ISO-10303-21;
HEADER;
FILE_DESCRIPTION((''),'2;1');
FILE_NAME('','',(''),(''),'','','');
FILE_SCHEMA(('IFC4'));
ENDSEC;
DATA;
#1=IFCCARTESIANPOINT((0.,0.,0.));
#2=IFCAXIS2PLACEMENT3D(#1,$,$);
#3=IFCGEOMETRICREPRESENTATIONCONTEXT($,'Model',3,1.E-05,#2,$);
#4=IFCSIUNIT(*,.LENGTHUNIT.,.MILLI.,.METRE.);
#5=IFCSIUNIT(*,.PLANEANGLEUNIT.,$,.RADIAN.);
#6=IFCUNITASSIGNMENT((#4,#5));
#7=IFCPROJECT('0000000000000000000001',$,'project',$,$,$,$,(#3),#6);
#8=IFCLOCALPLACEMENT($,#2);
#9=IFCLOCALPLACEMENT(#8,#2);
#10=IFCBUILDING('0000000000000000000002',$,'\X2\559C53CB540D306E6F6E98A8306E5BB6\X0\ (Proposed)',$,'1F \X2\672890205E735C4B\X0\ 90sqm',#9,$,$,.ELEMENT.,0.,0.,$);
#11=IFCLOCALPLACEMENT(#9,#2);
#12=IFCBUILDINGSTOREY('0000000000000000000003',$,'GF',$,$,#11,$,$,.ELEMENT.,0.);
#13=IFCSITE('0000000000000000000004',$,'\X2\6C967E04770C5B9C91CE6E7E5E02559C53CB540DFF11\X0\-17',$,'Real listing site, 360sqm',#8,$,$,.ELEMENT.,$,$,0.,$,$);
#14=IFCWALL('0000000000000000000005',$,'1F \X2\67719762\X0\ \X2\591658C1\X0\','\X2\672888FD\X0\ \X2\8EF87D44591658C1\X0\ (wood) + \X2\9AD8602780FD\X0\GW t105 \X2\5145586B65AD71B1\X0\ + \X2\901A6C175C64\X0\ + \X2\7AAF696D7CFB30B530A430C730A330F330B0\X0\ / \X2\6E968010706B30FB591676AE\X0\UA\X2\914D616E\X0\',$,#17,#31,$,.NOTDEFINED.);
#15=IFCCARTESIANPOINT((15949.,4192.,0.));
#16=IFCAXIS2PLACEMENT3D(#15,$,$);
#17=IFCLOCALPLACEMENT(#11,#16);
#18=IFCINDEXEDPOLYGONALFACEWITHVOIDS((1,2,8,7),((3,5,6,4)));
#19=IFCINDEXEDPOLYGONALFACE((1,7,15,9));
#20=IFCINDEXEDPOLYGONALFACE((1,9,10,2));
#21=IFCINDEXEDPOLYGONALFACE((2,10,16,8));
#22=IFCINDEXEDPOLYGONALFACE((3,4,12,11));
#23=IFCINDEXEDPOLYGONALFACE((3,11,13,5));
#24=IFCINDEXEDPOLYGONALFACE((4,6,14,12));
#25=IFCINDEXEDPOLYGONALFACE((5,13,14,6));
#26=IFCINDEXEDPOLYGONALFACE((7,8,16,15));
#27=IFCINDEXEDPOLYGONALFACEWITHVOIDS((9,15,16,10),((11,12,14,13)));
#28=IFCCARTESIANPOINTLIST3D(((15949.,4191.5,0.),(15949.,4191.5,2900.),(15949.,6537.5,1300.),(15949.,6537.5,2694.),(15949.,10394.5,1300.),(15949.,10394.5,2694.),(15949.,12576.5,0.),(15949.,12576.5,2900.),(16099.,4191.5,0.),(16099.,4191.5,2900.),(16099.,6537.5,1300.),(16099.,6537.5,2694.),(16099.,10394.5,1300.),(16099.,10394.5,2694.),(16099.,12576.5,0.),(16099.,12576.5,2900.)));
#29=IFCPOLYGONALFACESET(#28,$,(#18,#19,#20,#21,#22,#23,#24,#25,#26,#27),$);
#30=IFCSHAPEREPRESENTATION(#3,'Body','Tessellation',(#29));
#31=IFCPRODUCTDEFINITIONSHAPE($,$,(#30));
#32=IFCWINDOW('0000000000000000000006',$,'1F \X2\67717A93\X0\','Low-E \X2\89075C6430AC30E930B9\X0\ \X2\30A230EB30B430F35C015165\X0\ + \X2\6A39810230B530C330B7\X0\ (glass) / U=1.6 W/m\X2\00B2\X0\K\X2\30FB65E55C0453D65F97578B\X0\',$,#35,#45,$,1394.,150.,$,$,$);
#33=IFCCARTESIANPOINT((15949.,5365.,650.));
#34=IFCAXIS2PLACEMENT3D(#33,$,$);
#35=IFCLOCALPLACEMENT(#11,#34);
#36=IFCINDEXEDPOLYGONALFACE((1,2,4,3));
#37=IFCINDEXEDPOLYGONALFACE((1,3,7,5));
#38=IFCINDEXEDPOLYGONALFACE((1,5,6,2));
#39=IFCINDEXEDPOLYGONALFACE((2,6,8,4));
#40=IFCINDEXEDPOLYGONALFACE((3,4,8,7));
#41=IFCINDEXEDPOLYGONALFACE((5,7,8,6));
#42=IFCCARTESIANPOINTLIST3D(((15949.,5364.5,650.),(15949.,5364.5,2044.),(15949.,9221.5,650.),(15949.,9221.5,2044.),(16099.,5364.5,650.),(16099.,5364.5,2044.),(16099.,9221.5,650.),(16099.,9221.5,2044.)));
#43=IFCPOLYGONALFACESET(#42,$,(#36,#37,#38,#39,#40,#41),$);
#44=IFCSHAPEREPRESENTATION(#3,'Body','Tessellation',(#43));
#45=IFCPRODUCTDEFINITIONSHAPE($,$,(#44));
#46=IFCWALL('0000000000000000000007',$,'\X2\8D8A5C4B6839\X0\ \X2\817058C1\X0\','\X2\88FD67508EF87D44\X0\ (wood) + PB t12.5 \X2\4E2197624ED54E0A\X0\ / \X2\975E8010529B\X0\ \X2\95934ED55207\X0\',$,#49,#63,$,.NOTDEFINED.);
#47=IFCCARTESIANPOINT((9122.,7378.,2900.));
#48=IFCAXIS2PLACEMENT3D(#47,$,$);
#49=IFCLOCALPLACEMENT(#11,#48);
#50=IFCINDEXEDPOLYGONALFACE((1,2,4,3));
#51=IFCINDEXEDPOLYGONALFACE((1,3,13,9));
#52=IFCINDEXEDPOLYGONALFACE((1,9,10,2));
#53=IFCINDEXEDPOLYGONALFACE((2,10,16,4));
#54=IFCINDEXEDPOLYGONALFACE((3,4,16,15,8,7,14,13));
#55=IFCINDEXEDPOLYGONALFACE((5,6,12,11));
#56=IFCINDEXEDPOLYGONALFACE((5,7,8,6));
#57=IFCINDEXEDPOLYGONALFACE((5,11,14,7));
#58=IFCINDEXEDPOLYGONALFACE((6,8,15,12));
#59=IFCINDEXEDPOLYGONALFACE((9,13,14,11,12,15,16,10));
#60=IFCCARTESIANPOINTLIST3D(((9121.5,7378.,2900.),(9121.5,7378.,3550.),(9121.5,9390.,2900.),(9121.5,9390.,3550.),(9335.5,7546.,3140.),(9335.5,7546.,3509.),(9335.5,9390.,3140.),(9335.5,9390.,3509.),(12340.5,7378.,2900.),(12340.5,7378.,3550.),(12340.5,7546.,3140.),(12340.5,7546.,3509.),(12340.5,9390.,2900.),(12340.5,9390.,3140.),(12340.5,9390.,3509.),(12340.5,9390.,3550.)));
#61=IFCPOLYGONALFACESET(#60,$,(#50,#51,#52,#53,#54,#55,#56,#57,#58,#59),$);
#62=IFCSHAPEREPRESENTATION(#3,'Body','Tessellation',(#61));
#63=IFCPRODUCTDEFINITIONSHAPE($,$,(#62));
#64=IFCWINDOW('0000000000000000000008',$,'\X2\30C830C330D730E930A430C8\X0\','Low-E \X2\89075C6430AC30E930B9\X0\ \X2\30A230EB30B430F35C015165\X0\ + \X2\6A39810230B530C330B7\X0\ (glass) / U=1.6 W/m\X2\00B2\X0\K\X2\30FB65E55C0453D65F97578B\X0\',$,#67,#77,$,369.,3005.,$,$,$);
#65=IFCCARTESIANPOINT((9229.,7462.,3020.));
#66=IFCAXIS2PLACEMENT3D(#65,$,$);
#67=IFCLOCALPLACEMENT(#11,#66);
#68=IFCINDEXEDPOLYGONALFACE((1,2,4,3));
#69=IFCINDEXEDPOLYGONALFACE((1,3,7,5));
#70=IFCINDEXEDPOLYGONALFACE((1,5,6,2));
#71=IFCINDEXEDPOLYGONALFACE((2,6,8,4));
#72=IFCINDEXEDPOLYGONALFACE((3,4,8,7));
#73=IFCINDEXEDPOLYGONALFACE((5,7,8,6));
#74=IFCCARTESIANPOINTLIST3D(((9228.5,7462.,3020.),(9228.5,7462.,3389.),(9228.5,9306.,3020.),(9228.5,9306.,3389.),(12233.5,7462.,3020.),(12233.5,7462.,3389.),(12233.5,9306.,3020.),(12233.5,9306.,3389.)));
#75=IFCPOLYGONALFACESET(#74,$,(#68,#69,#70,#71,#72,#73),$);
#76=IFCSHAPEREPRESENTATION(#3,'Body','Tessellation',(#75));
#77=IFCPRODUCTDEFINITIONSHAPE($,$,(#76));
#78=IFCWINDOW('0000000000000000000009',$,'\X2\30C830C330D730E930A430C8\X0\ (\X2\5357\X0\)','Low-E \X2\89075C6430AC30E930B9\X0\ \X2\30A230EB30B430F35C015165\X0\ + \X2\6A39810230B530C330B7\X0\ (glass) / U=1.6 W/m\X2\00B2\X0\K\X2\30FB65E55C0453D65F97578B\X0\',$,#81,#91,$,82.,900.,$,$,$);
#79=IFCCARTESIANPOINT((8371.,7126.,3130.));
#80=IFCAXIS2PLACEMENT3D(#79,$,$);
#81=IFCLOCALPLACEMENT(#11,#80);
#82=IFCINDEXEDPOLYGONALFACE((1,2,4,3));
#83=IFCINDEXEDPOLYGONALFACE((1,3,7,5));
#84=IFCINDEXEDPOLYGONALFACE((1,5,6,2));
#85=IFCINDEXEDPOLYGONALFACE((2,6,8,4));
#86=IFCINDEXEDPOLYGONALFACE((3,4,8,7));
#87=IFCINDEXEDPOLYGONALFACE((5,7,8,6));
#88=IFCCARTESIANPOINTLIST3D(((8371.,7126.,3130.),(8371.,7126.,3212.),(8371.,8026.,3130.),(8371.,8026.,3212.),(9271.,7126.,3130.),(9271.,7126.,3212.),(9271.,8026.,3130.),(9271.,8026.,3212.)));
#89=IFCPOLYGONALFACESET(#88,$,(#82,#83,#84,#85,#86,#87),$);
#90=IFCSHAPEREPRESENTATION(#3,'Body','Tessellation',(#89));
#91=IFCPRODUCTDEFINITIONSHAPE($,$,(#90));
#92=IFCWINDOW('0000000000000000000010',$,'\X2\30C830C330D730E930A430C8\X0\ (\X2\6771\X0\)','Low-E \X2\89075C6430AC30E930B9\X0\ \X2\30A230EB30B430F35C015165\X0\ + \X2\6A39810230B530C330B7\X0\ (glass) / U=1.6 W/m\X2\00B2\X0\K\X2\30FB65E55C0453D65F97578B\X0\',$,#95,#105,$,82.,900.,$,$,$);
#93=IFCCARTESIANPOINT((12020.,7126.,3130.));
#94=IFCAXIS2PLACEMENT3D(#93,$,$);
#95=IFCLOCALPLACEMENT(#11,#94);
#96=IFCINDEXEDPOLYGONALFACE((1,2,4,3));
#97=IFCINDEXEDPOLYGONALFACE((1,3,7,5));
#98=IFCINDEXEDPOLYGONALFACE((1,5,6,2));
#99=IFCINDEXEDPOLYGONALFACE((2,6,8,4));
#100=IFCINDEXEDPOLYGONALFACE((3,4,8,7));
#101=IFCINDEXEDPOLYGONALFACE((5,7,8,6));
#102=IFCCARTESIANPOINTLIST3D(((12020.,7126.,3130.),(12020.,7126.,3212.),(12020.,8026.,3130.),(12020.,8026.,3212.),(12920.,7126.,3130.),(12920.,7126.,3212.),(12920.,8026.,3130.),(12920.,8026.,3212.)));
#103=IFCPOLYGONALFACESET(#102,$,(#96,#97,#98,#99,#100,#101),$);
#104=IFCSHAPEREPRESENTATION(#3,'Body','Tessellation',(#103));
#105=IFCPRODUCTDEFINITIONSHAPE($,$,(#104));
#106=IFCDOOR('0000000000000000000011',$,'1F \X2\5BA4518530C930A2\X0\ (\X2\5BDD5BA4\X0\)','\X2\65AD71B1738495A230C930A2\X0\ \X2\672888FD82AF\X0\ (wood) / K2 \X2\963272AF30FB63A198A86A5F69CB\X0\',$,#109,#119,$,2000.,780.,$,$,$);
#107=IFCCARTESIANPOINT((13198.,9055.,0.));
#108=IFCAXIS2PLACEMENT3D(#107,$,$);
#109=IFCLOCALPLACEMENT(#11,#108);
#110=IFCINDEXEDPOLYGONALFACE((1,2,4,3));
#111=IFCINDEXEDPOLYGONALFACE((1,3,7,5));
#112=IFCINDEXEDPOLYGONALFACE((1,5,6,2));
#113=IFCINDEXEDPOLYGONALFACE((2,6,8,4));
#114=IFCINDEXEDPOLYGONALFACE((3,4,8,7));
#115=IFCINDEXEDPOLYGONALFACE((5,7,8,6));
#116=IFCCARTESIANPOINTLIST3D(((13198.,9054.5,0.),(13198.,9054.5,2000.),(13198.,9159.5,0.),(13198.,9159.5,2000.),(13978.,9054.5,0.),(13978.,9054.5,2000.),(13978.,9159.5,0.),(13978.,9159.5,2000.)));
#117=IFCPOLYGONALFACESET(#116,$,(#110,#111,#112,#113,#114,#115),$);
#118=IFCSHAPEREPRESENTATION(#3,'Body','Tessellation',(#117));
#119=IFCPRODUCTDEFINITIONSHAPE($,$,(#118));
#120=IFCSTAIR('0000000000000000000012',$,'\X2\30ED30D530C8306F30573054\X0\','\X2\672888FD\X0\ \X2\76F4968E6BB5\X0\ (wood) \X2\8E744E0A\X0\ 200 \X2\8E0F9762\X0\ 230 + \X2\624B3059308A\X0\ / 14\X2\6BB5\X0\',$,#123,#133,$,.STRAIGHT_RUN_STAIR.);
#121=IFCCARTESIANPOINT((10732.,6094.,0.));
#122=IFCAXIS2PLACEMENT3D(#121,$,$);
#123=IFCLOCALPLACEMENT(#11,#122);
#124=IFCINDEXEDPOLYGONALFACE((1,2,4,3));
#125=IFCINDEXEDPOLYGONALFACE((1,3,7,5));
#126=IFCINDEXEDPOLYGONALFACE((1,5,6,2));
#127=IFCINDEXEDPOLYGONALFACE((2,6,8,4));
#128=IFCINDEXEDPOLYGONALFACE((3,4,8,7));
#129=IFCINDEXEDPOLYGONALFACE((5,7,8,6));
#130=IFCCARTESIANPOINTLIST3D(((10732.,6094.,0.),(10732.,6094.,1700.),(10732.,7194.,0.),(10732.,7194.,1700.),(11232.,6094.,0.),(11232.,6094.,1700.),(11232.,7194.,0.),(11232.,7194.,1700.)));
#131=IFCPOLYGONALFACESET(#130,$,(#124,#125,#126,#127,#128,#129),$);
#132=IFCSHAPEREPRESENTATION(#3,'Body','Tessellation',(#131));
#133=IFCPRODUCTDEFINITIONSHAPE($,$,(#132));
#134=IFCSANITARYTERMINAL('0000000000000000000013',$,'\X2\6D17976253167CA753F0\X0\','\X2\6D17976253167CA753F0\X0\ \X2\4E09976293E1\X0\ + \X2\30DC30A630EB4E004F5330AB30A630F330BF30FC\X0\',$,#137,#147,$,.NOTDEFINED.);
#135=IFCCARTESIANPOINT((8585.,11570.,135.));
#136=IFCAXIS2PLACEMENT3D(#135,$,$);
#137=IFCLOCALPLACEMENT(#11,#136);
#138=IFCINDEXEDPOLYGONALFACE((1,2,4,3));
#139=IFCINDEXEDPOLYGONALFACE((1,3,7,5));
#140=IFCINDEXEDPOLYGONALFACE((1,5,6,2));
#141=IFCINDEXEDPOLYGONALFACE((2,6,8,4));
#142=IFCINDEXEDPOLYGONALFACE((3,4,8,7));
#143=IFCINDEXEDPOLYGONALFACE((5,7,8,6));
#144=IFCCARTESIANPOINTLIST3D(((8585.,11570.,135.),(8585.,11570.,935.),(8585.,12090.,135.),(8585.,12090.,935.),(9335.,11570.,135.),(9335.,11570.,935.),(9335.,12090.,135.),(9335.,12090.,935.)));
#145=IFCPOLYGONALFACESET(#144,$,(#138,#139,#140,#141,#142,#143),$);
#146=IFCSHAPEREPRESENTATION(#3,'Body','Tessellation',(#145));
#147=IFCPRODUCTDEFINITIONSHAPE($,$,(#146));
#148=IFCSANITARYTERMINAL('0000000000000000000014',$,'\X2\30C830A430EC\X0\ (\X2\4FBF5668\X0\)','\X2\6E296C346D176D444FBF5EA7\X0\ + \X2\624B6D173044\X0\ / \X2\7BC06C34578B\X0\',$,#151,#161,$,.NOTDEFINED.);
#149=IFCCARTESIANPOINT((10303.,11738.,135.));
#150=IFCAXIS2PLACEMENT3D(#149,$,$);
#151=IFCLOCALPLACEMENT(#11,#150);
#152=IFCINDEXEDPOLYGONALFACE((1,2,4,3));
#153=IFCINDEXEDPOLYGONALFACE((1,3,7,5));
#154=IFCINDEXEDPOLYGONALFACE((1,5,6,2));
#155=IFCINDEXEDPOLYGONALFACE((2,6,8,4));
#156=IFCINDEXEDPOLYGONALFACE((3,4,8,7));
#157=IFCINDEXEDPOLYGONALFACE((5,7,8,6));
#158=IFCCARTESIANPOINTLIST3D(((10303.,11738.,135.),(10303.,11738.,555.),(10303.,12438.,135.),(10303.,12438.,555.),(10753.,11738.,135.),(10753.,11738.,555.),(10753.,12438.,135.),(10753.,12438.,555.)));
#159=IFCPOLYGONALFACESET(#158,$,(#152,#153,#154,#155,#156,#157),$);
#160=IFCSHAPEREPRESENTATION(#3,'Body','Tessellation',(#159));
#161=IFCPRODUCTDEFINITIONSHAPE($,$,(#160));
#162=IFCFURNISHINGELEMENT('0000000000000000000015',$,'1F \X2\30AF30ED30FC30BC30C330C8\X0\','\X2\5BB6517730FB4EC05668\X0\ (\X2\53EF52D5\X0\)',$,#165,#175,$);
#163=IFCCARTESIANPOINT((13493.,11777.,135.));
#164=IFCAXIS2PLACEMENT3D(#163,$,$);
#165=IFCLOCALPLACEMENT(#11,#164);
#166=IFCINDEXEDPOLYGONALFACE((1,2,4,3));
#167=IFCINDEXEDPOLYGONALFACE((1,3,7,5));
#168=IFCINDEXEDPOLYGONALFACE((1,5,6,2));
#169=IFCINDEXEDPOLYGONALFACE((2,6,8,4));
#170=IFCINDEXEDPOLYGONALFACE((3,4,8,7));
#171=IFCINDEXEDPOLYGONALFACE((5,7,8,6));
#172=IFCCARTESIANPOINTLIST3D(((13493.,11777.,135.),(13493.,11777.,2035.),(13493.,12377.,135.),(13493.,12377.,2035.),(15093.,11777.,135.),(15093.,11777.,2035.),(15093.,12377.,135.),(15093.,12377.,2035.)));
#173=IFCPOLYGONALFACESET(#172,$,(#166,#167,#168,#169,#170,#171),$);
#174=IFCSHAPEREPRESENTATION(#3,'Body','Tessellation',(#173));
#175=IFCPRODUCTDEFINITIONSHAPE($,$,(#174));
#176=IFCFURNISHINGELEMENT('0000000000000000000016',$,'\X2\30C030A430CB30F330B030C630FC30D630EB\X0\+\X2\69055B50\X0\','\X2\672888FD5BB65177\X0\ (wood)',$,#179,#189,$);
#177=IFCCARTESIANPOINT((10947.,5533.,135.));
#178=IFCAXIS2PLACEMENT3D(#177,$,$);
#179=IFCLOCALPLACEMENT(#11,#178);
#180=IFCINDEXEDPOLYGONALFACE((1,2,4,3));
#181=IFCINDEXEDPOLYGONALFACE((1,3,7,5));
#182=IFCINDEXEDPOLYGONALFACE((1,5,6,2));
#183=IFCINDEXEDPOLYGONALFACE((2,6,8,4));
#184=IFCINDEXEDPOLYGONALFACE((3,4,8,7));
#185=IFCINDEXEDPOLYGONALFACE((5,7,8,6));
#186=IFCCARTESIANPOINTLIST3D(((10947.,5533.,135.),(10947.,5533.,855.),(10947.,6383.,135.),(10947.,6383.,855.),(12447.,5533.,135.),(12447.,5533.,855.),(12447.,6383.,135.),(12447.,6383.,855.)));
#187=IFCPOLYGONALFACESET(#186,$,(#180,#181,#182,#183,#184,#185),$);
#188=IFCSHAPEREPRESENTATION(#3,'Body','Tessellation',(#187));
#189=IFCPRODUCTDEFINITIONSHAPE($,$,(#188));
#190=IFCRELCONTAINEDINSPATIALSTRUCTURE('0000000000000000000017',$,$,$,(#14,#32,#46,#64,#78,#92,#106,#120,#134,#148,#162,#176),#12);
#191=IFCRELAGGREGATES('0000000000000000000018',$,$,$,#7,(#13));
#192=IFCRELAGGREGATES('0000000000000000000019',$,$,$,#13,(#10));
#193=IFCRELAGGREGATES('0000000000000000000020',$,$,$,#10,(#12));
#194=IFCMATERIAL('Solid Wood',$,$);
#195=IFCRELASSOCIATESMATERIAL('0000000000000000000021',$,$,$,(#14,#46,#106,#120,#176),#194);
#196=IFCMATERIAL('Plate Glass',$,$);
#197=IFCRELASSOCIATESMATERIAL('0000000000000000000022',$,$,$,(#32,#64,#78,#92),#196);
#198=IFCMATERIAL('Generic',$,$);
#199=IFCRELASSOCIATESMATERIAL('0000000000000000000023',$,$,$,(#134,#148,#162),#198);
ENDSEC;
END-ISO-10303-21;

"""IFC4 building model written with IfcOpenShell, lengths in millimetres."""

from ifc_helpers import new_model, si_unit, frame, frame_2d, origin, place, context, project, spatial, rectangle, extrude, material, element, fill, save


model = new_model("IFC4")

# Units and contexts
model_context = context("Model", 3, precision=1e-05, world=origin())
ifc_project = project(units=[si_unit("LENGTHUNIT", "METRE", prefix="MILLI"), si_unit("PLANEANGLEUNIT", "RADIAN")], contexts=[model_context])

# Site, building, storey
site_placement = place(None, origin())
site = spatial("IfcSite", under=ifc_project, at=site_placement, Name="沖縄県宜野湾市喜友名１-17", ObjectType="Real listing site, 360sqm", CompositionType="ELEMENT", RefElevation=0.0)
building_placement = place(site_placement, origin())
building = spatial("IfcBuilding", under=site, at=building_placement, Name="喜友名の潮風の家 (Proposed)", ObjectType="1F 木造平屋 90sqm", CompositionType="ELEMENT", ElevationOfRefHeight=0.0, ElevationOfTerrain=0.0)
storey_placement = place(building_placement, origin())
storey = spatial("IfcBuildingStorey", under=building, at=storey_placement, Name="GF", CompositionType="ELEMENT", Elevation=0.0)

# Wall, opening, window
ifc_material_1 = material(Name="Solid Wood")
wall_1_placement = place(storey_placement, frame((15949.0, 4192.0, 0.0)))
wall_1 = element("IfcWall", 1, at=wall_1_placement, inside=storey, material=ifc_material_1, Name="1F 東面 外壁", Description="木製 軸組外壁 (wood) + 高性能GW t105 充填断熱 + 通気層 + 窯業系サイディング / 準耐火・外皮UA配慮", PredefinedType="NOTDEFINED", context=model_context, shape_type="SweptSolid", body=[
    extrude(rectangle(XDim=150.0, YDim=8385.0, at=frame_2d((75.0, 4192.0))), frame((15949.0, 4192.0, 0.0)), (0.0, 0.0, 1.0), 2900.0),
])
opening_1_placement = place(storey_placement, frame((15949.0, 5365.0, 650.0)))
opening_1 = element("IfcOpeningElement", 2, at=opening_1_placement, cuts=wall_1, PredefinedType="NOTDEFINED", context=model_context, shape_type="SweptSolid", body=[
    extrude(rectangle(XDim=150.0, YDim=3857.0, at=frame_2d((75.0, 1928.0))), frame((15949.0, 5365.0, 650.0)), (0.0, 0.0, 1.0), 1394.0),
])
ifc_material_2 = material(Name="Plate Glass")
window_1_placement = place(storey_placement, frame((15949.0, 5365.0, 650.0)))
window_1 = element("IfcWindow", 3, at=window_1_placement, inside=storey, material=ifc_material_2, Name="1F 東窓", Description="Low-E 複層ガラス アルゴン封入 + 樹脂サッシ (glass) / U=1.6 W/m²K・日射取得型", OverallHeight=1394.0, OverallWidth=150.0, context=model_context, shape_type="SweptSolid", body=[
    extrude(rectangle(XDim=150.0, YDim=3857.0, at=frame_2d((75.0, 1928.0))), frame((15949.0, 5365.0, 650.0)), (0.0, 0.0, 1.0), 1394.0),
])
fill(opening_1, window_1)

# Wall, openings, windows
wall_2_placement = place(storey_placement, frame((9122.0, 7378.0, 2900.0)))
wall_2 = element("IfcWall", 4, at=wall_2_placement, inside=storey, material=ifc_material_1, Name="越屋根 腰壁", Description="製材軸組 (wood) + PB t12.5 両面仕上 / 非耐力 間仕切", PredefinedType="NOTDEFINED", context=model_context, shape_type="SweptSolid", body=[
    extrude(rectangle(XDim=3219.0, YDim=2012.0, at=frame_2d((1609.0, 1006.0))), frame((9122.0, 7378.0, 2900.0)), (0.0, 0.0, 1.0), 650.0),
])
opening_2_placement = place(storey_placement, frame((9229.0, 7462.0, 3020.0)))
opening_2 = element("IfcOpeningElement", 5, at=opening_2_placement, cuts=wall_2, PredefinedType="NOTDEFINED", context=model_context, shape_type="SweptSolid", body=[
    extrude(rectangle(XDim=3005.0, YDim=1844.0, at=frame_2d((1502.0, 922.0))), frame((9229.0, 7462.0, 3020.0)), (0.0, 0.0, 1.0), 369.0),
])
opening_3_placement = place(storey_placement, frame((8371.0, 7126.0, 3130.0)))
opening_3 = element("IfcOpeningElement", 6, at=opening_3_placement, cuts=wall_2, PredefinedType="NOTDEFINED", context=model_context, shape_type="SweptSolid", body=[
    extrude(rectangle(XDim=900.0, YDim=900.0, at=frame_2d((450.0, 450.0))), frame((8371.0, 7126.0, 3130.0)), (0.0, 0.0, 1.0), 82.0),
])
opening_4_placement = place(storey_placement, frame((12020.0, 7126.0, 3130.0)))
opening_4 = element("IfcOpeningElement", 7, at=opening_4_placement, cuts=wall_2, PredefinedType="NOTDEFINED", context=model_context, shape_type="SweptSolid", body=[
    extrude(rectangle(XDim=900.0, YDim=900.0, at=frame_2d((450.0, 450.0))), frame((12020.0, 7126.0, 3130.0)), (0.0, 0.0, 1.0), 82.0),
])
window_2_placement = place(storey_placement, frame((9229.0, 7462.0, 3020.0)))
window_2 = element("IfcWindow", 8, at=window_2_placement, inside=storey, material=ifc_material_2, Name="トップライト", Description="Low-E 複層ガラス アルゴン封入 + 樹脂サッシ (glass) / U=1.6 W/m²K・日射取得型", OverallHeight=369.0, OverallWidth=3005.0, context=model_context, shape_type="SweptSolid", body=[
    extrude(rectangle(XDim=3005.0, YDim=1844.0, at=frame_2d((1502.0, 922.0))), frame((9229.0, 7462.0, 3020.0)), (0.0, 0.0, 1.0), 369.0),
])
fill(opening_2, window_2)
window_3_placement = place(storey_placement, frame((8371.0, 7126.0, 3130.0)))
window_3 = element("IfcWindow", 9, at=window_3_placement, inside=storey, material=ifc_material_2, Name="トップライト (南)", Description="Low-E 複層ガラス アルゴン封入 + 樹脂サッシ (glass) / U=1.6 W/m²K・日射取得型", OverallHeight=82.0, OverallWidth=900.0, context=model_context, shape_type="SweptSolid", body=[
    extrude(rectangle(XDim=900.0, YDim=900.0, at=frame_2d((450.0, 450.0))), frame((8371.0, 7126.0, 3130.0)), (0.0, 0.0, 1.0), 82.0),
])
fill(opening_3, window_3)
window_4_placement = place(storey_placement, frame((12020.0, 7126.0, 3130.0)))
window_4 = element("IfcWindow", 10, at=window_4_placement, inside=storey, material=ifc_material_2, Name="トップライト (東)", Description="Low-E 複層ガラス アルゴン封入 + 樹脂サッシ (glass) / U=1.6 W/m²K・日射取得型", OverallHeight=82.0, OverallWidth=900.0, context=model_context, shape_type="SweptSolid", body=[
    extrude(rectangle(XDim=900.0, YDim=900.0, at=frame_2d((450.0, 450.0))), frame((12020.0, 7126.0, 3130.0)), (0.0, 0.0, 1.0), 82.0),
])
fill(opening_4, window_4)

# Door
door_placement = place(storey_placement, frame((13198.0, 9055.0, 0.0)))
element("IfcDoor", 11, at=door_placement, inside=storey, material=ifc_material_1, Name="1F 室内ドア (寝室)", Description="断熱玄関ドア 木製芯 (wood) / K2 防犯・採風機構", OverallHeight=2000.0, OverallWidth=780.0, context=model_context, shape_type="SweptSolid", body=[
    extrude(rectangle(XDim=780.0, YDim=105.0, at=frame_2d((390.0, 52.0))), frame((13198.0, 9055.0, 0.0)), (0.0, 0.0, 1.0), 2000.0),
])

# Stair
stair_placement = place(storey_placement, frame((10732.0, 6094.0, 0.0)))
element("IfcStair", 12, at=stair_placement, inside=storey, material=ifc_material_1, Name="ロフトはしご", Description="木製 直階段 (wood) 蹴上 200 踏面 230 + 手すり / 14段", PredefinedType="STRAIGHT_RUN_STAIR", context=model_context, shape_type="SweptSolid", body=[
    extrude(rectangle(XDim=500.0, YDim=1100.0, at=frame_2d((250.0, 550.0))), frame((10732.0, 6094.0, 0.0)), (0.0, 0.0, 1.0), 1700.0),
])

# Sanitary terminals
ifc_material_3 = material(Name="Generic")
sanitary_terminal_1_placement = place(storey_placement, frame((8585.0, 11570.0, 135.0)))
element("IfcSanitaryTerminal", 13, at=sanitary_terminal_1_placement, inside=storey, material=ifc_material_3, Name="洗面化粧台", Description="洗面化粧台 三面鏡 + ボウル一体カウンター", PredefinedType="NOTDEFINED", context=model_context, shape_type="SweptSolid", body=[
    extrude(rectangle(XDim=750.0, YDim=520.0, at=frame_2d((375.0, 260.0))), frame((8585.0, 11570.0, 135.0)), (0.0, 0.0, 1.0), 800.0),
])
sanitary_terminal_2_placement = place(storey_placement, frame((10303.0, 11738.0, 135.0)))
element("IfcSanitaryTerminal", 14, at=sanitary_terminal_2_placement, inside=storey, material=ifc_material_3, Name="トイレ (便器)", Description="温水洗浄便座 + 手洗い / 節水型", PredefinedType="NOTDEFINED", context=model_context, shape_type="SweptSolid", body=[
    extrude(rectangle(XDim=450.0, YDim=700.0, at=frame_2d((225.0, 350.0))), frame((10303.0, 11738.0, 135.0)), (0.0, 0.0, 1.0), 420.0),
])

# Furnishing elements
furnishing_1_placement = place(storey_placement, frame((13493.0, 11777.0, 135.0)))
element("IfcFurnishingElement", 15, at=furnishing_1_placement, inside=storey, material=ifc_material_3, Name="1F クローゼット", Description="家具・什器 (可動)", context=model_context, shape_type="SweptSolid", body=[
    extrude(rectangle(XDim=1600.0, YDim=600.0, at=frame_2d((800.0, 300.0))), frame((13493.0, 11777.0, 135.0)), (0.0, 0.0, 1.0), 1900.0),
])
furnishing_2_placement = place(storey_placement, frame((10947.0, 5533.0, 135.0)))
element("IfcFurnishingElement", 16, at=furnishing_2_placement, inside=storey, material=ifc_material_1, Name="ダイニングテーブル+椅子", Description="木製家具 (wood)", context=model_context, shape_type="SweptSolid", body=[
    extrude(rectangle(XDim=1500.0, YDim=850.0, at=frame_2d((750.0, 425.0))), frame((10947.0, 5533.0, 135.0)), (0.0, 0.0, 1.0), 720.0),
])

save(model, "model.ifc")
